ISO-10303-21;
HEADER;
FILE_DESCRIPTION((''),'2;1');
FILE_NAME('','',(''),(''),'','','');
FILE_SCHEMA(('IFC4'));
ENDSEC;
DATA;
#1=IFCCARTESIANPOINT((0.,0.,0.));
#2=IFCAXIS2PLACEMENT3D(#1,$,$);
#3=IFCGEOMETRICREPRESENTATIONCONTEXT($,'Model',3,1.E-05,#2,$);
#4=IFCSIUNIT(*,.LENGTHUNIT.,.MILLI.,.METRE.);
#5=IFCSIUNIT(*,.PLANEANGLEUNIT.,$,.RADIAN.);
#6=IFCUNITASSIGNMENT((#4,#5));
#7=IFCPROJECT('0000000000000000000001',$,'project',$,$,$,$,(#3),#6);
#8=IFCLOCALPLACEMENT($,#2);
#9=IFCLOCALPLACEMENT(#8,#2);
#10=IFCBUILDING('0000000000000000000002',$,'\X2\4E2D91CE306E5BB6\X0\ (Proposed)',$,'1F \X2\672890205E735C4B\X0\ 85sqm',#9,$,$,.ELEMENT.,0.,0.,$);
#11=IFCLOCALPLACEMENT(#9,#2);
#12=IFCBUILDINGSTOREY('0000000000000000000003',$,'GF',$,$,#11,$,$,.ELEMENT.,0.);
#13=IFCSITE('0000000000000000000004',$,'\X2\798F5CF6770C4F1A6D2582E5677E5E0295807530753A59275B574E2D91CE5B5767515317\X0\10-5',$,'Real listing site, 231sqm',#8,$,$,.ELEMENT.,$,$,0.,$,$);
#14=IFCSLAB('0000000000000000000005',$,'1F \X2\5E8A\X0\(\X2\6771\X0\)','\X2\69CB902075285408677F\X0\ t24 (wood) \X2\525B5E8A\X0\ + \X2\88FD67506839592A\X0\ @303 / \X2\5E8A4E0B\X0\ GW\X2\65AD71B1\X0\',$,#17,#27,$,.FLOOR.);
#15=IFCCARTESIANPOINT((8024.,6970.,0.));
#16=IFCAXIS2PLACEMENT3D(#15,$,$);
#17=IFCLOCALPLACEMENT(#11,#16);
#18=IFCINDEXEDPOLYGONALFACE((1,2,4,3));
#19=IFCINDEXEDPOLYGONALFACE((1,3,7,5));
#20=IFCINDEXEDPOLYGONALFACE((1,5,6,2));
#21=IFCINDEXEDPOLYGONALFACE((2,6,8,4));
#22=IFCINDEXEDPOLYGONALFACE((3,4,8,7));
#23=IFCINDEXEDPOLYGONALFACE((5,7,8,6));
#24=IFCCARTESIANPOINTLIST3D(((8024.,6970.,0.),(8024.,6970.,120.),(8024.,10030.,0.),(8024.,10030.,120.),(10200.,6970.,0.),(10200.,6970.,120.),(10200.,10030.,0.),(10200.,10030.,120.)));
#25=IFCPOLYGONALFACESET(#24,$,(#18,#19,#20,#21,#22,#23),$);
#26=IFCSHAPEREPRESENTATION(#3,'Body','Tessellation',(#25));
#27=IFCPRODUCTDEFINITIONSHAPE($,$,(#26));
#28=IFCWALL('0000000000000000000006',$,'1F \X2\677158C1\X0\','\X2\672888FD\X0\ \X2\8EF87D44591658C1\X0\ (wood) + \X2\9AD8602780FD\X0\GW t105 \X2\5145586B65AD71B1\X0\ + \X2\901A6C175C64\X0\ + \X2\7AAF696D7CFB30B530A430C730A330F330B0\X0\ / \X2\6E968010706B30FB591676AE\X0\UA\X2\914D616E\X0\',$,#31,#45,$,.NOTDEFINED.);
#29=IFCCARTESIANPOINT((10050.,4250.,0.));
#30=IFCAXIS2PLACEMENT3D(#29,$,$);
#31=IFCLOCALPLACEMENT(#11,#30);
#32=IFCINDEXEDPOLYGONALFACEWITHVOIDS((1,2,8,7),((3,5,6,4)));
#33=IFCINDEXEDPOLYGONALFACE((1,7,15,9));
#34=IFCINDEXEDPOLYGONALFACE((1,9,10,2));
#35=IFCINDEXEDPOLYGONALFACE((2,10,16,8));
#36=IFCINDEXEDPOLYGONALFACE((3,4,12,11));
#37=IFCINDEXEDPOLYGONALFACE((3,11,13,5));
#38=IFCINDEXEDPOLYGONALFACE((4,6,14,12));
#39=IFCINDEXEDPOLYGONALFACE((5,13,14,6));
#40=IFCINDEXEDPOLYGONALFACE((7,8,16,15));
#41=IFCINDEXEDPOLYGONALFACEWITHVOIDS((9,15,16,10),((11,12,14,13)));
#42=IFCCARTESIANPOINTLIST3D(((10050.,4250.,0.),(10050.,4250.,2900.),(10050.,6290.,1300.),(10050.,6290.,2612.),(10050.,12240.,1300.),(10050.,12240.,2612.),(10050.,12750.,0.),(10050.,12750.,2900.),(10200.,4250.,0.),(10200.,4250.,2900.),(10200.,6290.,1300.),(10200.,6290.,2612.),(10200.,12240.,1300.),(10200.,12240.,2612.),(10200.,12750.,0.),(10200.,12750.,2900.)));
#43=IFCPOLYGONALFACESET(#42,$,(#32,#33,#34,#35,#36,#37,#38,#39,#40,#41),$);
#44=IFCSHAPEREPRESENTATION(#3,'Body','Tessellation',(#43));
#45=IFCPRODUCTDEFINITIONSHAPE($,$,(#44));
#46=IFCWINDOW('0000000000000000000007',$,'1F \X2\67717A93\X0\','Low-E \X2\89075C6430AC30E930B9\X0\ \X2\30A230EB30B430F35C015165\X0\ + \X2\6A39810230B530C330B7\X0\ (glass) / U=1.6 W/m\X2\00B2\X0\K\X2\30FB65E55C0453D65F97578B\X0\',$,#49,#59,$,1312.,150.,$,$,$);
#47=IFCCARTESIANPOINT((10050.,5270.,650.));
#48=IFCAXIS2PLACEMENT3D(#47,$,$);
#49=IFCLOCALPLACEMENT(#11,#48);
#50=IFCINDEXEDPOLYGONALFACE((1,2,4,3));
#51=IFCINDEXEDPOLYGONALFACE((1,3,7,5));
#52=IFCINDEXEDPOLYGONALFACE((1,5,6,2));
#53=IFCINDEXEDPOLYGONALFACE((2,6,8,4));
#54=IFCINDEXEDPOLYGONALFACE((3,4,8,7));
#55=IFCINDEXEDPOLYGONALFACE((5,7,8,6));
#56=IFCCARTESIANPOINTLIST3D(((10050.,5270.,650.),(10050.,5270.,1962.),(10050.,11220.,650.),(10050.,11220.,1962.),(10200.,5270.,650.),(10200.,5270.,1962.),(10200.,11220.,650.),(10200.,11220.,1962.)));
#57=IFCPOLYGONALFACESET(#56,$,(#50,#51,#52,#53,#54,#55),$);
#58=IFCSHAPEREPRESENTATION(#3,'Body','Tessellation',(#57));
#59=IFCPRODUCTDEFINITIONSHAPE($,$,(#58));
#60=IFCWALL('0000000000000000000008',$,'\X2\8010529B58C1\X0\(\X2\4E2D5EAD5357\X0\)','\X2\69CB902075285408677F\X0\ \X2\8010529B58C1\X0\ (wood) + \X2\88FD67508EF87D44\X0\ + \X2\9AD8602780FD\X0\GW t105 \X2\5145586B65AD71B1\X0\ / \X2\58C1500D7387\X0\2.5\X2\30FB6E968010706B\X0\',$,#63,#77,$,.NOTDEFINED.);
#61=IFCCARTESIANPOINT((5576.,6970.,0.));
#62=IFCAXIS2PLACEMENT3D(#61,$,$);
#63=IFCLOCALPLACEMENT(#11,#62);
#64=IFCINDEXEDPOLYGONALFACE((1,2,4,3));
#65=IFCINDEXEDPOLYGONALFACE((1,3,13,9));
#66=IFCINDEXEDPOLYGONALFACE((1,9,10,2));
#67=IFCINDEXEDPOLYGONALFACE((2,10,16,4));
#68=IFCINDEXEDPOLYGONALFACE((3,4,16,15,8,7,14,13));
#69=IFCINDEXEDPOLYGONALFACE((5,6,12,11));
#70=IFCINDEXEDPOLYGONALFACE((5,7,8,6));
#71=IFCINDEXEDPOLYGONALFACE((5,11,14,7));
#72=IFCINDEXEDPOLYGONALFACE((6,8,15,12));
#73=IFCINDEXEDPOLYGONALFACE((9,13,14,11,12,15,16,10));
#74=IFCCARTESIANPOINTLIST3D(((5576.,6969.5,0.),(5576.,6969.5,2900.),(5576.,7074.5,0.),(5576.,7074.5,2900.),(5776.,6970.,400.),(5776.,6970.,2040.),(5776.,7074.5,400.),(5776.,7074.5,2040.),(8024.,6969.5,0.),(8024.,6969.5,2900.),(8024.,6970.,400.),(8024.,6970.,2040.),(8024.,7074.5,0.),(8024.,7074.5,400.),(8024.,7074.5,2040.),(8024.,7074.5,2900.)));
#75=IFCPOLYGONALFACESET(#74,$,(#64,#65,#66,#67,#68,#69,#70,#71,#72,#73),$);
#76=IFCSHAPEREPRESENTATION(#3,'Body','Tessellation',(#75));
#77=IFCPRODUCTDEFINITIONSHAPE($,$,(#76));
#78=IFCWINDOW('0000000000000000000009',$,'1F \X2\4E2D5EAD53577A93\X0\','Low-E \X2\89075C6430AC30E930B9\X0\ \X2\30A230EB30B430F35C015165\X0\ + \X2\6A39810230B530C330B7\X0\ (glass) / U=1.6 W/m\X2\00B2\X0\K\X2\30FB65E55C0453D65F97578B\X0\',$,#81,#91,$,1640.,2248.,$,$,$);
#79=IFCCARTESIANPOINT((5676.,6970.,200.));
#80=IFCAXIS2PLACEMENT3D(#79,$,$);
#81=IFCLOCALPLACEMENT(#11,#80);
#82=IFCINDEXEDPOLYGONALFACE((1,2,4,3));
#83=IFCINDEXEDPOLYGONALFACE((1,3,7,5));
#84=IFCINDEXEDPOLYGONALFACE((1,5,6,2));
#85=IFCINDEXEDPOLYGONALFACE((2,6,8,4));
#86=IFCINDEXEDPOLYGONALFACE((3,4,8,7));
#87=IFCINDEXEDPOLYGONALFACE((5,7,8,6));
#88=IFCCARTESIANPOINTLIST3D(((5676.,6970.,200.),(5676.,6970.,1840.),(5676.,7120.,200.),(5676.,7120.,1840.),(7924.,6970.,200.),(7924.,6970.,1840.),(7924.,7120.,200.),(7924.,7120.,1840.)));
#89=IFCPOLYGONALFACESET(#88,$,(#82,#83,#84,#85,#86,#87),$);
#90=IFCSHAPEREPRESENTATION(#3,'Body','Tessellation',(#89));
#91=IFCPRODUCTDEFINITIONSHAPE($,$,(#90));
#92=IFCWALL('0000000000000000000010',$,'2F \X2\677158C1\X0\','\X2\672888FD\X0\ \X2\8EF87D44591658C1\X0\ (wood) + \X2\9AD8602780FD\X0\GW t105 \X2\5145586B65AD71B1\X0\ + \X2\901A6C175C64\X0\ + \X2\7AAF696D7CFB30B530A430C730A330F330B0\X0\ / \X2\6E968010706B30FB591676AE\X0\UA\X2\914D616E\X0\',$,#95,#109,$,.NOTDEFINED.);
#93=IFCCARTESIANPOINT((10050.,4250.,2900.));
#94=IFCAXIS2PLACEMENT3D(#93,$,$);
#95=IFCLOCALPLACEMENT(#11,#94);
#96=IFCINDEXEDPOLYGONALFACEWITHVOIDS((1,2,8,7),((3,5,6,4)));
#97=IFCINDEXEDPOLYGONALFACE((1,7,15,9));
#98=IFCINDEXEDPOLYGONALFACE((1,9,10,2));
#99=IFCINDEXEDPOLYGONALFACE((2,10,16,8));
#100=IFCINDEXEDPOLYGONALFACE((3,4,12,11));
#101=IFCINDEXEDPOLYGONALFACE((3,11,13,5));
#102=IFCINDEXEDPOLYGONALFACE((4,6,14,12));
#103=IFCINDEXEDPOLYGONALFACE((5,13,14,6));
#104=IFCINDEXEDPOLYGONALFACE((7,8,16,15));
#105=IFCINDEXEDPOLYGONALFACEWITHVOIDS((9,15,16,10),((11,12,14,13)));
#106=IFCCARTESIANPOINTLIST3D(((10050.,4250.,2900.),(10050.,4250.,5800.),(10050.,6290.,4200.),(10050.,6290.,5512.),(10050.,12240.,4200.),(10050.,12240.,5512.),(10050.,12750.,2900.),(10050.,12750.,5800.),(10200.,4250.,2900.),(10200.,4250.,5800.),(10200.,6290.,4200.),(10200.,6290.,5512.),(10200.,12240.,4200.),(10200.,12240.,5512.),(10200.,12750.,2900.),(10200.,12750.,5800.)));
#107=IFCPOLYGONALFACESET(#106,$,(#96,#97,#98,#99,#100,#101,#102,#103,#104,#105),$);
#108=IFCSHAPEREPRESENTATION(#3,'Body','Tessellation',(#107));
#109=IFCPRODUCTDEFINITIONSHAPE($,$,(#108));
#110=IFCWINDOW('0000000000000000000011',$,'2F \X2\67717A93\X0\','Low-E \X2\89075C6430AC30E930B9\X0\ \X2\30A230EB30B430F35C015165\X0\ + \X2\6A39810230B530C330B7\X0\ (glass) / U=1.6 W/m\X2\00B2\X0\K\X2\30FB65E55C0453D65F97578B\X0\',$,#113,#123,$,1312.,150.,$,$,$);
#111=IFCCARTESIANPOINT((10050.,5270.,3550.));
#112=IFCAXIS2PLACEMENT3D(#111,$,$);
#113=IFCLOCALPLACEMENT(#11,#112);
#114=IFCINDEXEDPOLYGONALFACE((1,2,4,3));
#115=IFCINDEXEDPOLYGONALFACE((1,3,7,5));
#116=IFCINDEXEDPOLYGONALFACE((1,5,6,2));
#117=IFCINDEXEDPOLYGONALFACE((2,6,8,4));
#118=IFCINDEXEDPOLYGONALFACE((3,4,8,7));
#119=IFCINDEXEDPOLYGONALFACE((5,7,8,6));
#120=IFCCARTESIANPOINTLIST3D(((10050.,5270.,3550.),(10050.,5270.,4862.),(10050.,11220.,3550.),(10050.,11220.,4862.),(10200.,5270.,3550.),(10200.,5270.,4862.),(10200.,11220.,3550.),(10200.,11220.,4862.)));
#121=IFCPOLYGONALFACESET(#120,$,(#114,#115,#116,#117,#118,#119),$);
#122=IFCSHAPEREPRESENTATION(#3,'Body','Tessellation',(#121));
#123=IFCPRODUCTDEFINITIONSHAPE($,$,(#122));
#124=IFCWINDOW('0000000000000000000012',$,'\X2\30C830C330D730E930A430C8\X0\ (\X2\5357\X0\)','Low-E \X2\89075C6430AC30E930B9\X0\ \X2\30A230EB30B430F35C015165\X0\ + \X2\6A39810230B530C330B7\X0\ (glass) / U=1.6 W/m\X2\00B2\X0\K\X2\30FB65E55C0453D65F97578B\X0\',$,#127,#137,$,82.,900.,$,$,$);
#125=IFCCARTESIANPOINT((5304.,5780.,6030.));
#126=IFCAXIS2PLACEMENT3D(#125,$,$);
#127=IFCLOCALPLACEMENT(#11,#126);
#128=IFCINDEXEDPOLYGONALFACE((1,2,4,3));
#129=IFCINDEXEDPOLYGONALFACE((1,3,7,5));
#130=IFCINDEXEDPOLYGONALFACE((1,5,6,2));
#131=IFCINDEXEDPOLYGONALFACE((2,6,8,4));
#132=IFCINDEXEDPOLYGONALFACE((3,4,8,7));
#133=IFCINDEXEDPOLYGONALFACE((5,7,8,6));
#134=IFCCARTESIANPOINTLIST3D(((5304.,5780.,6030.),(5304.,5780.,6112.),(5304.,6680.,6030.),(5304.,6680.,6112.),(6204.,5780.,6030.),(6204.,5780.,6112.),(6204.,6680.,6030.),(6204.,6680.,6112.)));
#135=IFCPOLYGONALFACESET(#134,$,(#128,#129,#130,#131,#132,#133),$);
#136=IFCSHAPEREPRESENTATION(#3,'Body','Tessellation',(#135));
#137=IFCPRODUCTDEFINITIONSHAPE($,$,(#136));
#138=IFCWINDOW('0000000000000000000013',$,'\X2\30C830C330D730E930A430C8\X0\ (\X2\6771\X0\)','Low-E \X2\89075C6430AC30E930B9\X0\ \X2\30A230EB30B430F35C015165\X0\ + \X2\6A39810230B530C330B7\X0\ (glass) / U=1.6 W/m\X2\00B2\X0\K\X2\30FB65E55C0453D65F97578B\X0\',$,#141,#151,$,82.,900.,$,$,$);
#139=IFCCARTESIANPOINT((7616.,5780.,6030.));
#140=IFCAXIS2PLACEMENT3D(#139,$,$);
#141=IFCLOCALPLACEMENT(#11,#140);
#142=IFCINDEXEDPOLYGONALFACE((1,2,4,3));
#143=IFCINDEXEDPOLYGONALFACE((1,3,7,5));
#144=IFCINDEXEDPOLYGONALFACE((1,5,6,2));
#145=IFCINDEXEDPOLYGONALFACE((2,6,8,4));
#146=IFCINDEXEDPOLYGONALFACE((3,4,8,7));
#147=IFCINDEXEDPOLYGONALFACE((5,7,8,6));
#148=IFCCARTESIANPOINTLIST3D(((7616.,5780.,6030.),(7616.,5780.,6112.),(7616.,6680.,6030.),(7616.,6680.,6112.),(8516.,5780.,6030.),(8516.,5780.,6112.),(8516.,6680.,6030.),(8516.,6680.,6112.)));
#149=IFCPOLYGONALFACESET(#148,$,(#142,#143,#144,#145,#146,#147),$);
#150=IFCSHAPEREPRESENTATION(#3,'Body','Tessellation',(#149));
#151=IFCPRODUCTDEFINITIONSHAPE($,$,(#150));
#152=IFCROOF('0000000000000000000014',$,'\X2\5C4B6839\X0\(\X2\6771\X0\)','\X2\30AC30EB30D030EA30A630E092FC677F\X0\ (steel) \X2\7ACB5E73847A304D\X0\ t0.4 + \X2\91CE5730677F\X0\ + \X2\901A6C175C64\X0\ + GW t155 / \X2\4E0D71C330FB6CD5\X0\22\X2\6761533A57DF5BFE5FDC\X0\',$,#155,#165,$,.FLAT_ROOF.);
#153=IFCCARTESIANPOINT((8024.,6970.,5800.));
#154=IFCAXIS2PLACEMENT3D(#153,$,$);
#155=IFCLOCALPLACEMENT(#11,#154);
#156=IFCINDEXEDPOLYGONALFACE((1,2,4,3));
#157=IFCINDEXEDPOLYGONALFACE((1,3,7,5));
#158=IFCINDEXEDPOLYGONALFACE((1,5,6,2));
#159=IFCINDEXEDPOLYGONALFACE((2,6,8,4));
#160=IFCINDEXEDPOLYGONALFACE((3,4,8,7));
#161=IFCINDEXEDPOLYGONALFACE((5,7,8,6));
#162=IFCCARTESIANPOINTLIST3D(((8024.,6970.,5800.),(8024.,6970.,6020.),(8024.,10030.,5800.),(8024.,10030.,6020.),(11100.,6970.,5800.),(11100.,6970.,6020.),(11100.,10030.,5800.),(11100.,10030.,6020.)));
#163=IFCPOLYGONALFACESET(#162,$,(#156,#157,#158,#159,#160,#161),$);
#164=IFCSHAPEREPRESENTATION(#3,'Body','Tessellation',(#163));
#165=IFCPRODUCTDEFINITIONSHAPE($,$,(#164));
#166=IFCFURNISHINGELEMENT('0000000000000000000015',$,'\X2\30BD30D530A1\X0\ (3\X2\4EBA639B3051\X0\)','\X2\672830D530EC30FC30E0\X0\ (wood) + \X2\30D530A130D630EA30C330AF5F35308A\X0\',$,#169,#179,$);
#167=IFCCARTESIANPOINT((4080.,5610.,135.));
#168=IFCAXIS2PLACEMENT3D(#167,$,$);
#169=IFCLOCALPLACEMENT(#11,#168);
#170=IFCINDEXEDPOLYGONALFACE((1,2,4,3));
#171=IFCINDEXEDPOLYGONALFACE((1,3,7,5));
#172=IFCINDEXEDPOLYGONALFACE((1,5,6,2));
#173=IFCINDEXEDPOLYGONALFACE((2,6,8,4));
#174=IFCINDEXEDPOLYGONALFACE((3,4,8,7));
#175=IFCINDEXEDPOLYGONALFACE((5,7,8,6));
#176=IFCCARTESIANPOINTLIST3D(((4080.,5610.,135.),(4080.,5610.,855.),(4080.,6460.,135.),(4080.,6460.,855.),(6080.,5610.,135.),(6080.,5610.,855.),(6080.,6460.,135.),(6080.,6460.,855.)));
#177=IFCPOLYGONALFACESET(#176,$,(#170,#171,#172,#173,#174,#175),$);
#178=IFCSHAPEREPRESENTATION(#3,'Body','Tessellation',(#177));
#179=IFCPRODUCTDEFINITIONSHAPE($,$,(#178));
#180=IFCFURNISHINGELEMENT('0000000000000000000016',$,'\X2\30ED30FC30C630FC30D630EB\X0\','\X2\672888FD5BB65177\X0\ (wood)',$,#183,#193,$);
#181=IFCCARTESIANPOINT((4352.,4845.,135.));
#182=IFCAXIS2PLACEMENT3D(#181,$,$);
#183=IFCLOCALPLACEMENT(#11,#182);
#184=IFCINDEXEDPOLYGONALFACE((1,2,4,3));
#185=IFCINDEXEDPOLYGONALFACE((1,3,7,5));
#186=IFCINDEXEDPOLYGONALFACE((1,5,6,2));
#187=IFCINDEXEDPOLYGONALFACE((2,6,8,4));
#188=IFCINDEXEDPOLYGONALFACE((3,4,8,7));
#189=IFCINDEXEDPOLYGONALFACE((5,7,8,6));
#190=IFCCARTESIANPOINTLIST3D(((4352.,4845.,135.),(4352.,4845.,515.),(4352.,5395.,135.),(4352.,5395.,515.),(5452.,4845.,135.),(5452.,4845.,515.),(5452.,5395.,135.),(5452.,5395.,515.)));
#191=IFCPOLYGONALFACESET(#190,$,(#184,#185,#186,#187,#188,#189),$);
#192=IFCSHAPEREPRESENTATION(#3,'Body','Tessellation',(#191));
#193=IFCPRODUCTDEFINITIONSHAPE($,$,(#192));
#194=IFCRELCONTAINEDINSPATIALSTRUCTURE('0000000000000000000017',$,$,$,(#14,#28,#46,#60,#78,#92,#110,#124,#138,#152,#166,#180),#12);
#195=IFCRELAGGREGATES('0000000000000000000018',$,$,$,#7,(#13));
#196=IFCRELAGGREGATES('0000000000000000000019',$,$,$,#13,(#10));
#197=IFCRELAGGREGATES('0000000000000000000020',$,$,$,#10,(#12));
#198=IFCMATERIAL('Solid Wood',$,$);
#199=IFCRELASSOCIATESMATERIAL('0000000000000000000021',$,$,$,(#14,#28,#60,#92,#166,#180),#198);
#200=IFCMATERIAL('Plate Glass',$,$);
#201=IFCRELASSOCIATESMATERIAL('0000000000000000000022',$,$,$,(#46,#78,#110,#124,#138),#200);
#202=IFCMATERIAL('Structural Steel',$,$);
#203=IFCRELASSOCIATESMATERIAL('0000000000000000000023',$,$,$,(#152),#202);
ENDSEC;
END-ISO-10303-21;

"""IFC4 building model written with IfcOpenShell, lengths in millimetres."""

from ifc_helpers import new_model, si_unit, frame, frame_2d, origin, place, context, project, spatial, rectangle, extrude, material, element, fill, save


model = new_model("IFC4")

# Units and contexts
model_context = context("Model", 3, precision=1e-05, world=origin())
ifc_project = project(units=[si_unit("LENGTHUNIT", "METRE", prefix="MILLI"), si_unit("PLANEANGLEUNIT", "RADIAN")], contexts=[model_context])

# Site, building, storey
site_placement = place(None, origin())
site = spatial("IfcSite", under=ifc_project, at=site_placement, Name="福島県会津若松市門田町大字中野字村北10-5", ObjectType="Real listing site, 231sqm", CompositionType="ELEMENT", RefElevation=0.0)
building_placement = place(site_placement, origin())
building = spatial("IfcBuilding", under=site, at=building_placement, Name="中野の家 (Proposed)", ObjectType="1F 木造平屋 85sqm", CompositionType="ELEMENT", ElevationOfRefHeight=0.0, ElevationOfTerrain=0.0)
storey_placement = place(building_placement, origin())
storey = spatial("IfcBuildingStorey", under=building, at=storey_placement, Name="GF", CompositionType="ELEMENT", Elevation=0.0)

# Slab
ifc_material_1 = material(Name="Solid Wood")
slab_placement = place(storey_placement, frame((8024.0, 6970.0, 0.0)))
element("IfcSlab", 1, at=slab_placement, inside=storey, material=ifc_material_1, Name="1F 床(東)", Description="構造用合板 t24 (wood) 剛床 + 製材根太 @303 / 床下 GW断熱", PredefinedType="FLOOR", context=model_context, shape_type="SweptSolid", body=[
    extrude(rectangle(XDim=2176.0, YDim=3060.0, at=frame_2d((1088.0, 1530.0))), frame((8024.0, 6970.0, 0.0)), (0.0, 0.0, 1.0), 120.0),
])

# Walls, openings, windows
wall_1_placement = place(storey_placement, frame((10050.0, 4250.0, 0.0)))
wall_1 = element("IfcWall", 2, at=wall_1_placement, inside=storey, material=ifc_material_1, Name="1F 東壁", Description="木製 軸組外壁 (wood) + 高性能GW t105 充填断熱 + 通気層 + 窯業系サイディング / 準耐火・外皮UA配慮", PredefinedType="NOTDEFINED", context=model_context, shape_type="SweptSolid", body=[
    extrude(rectangle(XDim=150.0, YDim=8500.0, at=frame_2d((75.0, 4250.0))), frame((10050.0, 4250.0, 0.0)), (0.0, 0.0, 1.0), 2900.0),
])
opening_1_placement = place(storey_placement, frame((10050.0, 5270.0, 650.0)))
opening_1 = element("IfcOpeningElement", 3, at=opening_1_placement, cuts=wall_1, PredefinedType="NOTDEFINED", context=model_context, shape_type="SweptSolid", body=[
    extrude(rectangle(XDim=150.0, YDim=5950.0, at=frame_2d((75.0, 2975.0))), frame((10050.0, 5270.0, 650.0)), (0.0, 0.0, 1.0), 1312.0),
])
ifc_material_2 = material(Name="Plate Glass")
window_1_placement = place(storey_placement, frame((10050.0, 5270.0, 650.0)))
window_1 = element("IfcWindow", 4, at=window_1_placement, inside=storey, material=ifc_material_2, Name="1F 東窓", Description="Low-E 複層ガラス アルゴン封入 + 樹脂サッシ (glass) / U=1.6 W/m²K・日射取得型", OverallHeight=1312.0, OverallWidth=150.0, context=model_context, shape_type="SweptSolid", body=[
    extrude(rectangle(XDim=150.0, YDim=5950.0, at=frame_2d((75.0, 2975.0))), frame((10050.0, 5270.0, 650.0)), (0.0, 0.0, 1.0), 1312.0),
])
fill(opening_1, window_1)
wall_2_placement = place(storey_placement, frame((5576.0, 6970.0, 0.0)))
wall_2 = element("IfcWall", 5, at=wall_2_placement, inside=storey, material=ifc_material_1, Name="耐力壁(中庭南)", Description="構造用合板 耐力壁 (wood) + 製材軸組 + 高性能GW t105 充填断熱 / 壁倍率2.5・準耐火", PredefinedType="NOTDEFINED", context=model_context, shape_type="SweptSolid", body=[
    extrude(rectangle(XDim=2448.0, YDim=105.0, at=frame_2d((1224.0, 52.0))), frame((5576.0, 6970.0, 0.0)), (0.0, 0.0, 1.0), 2900.0),
])
opening_2_placement = place(storey_placement, frame((5676.0, 6970.0, 200.0)))
opening_2 = element("IfcOpeningElement", 6, at=opening_2_placement, cuts=wall_2, PredefinedType="NOTDEFINED", context=model_context, shape_type="SweptSolid", body=[
    extrude(rectangle(XDim=2248.0, YDim=150.0, at=frame_2d((1124.0, 75.0))), frame((5676.0, 6970.0, 200.0)), (0.0, 0.0, 1.0), 1640.0),
])
window_2_placement = place(storey_placement, frame((5676.0, 6970.0, 200.0)))
window_2 = element("IfcWindow", 7, at=window_2_placement, inside=storey, material=ifc_material_2, Name="1F 中庭南窓", Description="Low-E 複層ガラス アルゴン封入 + 樹脂サッシ (glass) / U=1.6 W/m²K・日射取得型", OverallHeight=1640.0, OverallWidth=2248.0, context=model_context, shape_type="SweptSolid", body=[
    extrude(rectangle(XDim=2248.0, YDim=150.0, at=frame_2d((1124.0, 75.0))), frame((5676.0, 6970.0, 200.0)), (0.0, 0.0, 1.0), 1640.0),
])
fill(opening_2, window_2)

# Wall, opening, window
wall_3_placement = place(storey_placement, frame((10050.0, 4250.0, 2900.0)))
wall_3 = element("IfcWall", 8, at=wall_3_placement, inside=storey, material=ifc_material_1, Name="2F 東壁", Description="木製 軸組外壁 (wood) + 高性能GW t105 充填断熱 + 通気層 + 窯業系サイディング / 準耐火・外皮UA配慮", PredefinedType="NOTDEFINED", context=model_context, shape_type="SweptSolid", body=[
    extrude(rectangle(XDim=150.0, YDim=8500.0, at=frame_2d((75.0, 4250.0))), frame((10050.0, 4250.0, 2900.0)), (0.0, 0.0, 1.0), 2900.0),
])
opening_3_placement = place(storey_placement, frame((10050.0, 5270.0, 3550.0)))
opening_3 = element("IfcOpeningElement", 9, at=opening_3_placement, cuts=wall_3, PredefinedType="NOTDEFINED", context=model_context, shape_type="SweptSolid", body=[
    extrude(rectangle(XDim=150.0, YDim=5950.0, at=frame_2d((75.0, 2975.0))), frame((10050.0, 5270.0, 3550.0)), (0.0, 0.0, 1.0), 1312.0),
])
window_3_placement = place(storey_placement, frame((10050.0, 5270.0, 3550.0)))
window_3 = element("IfcWindow", 10, at=window_3_placement, inside=storey, material=ifc_material_2, Name="2F 東窓", Description="Low-E 複層ガラス アルゴン封入 + 樹脂サッシ (glass) / U=1.6 W/m²K・日射取得型", OverallHeight=1312.0, OverallWidth=150.0, context=model_context, shape_type="SweptSolid", body=[
    extrude(rectangle(XDim=150.0, YDim=5950.0, at=frame_2d((75.0, 2975.0))), frame((10050.0, 5270.0, 3550.0)), (0.0, 0.0, 1.0), 1312.0),
])
fill(opening_3, window_3)

# Windows
window_4_placement = place(storey_placement, frame((5304.0, 5780.0, 6030.0)))
element("IfcWindow", 11, at=window_4_placement, inside=storey, material=ifc_material_2, Name="トップライト (南)", Description="Low-E 複層ガラス アルゴン封入 + 樹脂サッシ (glass) / U=1.6 W/m²K・日射取得型", OverallHeight=82.0, OverallWidth=900.0, context=model_context, shape_type="SweptSolid", body=[
    extrude(rectangle(XDim=900.0, YDim=900.0, at=frame_2d((450.0, 450.0))), frame((5304.0, 5780.0, 6030.0)), (0.0, 0.0, 1.0), 82.0),
])
window_5_placement = place(storey_placement, frame((7616.0, 5780.0, 6030.0)))
element("IfcWindow", 12, at=window_5_placement, inside=storey, material=ifc_material_2, Name="トップライト (東)", Description="Low-E 複層ガラス アルゴン封入 + 樹脂サッシ (glass) / U=1.6 W/m²K・日射取得型", OverallHeight=82.0, OverallWidth=900.0, context=model_context, shape_type="SweptSolid", body=[
    extrude(rectangle(XDim=900.0, YDim=900.0, at=frame_2d((450.0, 450.0))), frame((7616.0, 5780.0, 6030.0)), (0.0, 0.0, 1.0), 82.0),
])

# Roof
ifc_material_3 = material(Name="Structural Steel")
roof_placement = place(storey_placement, frame((8024.0, 6970.0, 5800.0)))
element("IfcRoof", 13, at=roof_placement, inside=storey, material=ifc_material_3, Name="屋根(東)", Description="ガルバリウム鋼板 (steel) 立平葺き t0.4 + 野地板 + 通気層 + GW t155 / 不燃・法22条区域対応", PredefinedType="FLAT_ROOF", context=model_context, shape_type="SweptSolid", body=[
    extrude(rectangle(XDim=3076.0, YDim=3060.0, at=frame_2d((1538.0, 1530.0))), frame((8024.0, 6970.0, 5800.0)), (0.0, 0.0, 1.0), 220.0),
])

# Furnishing elements
furnishing_1_placement = place(storey_placement, frame((4080.0, 5610.0, 135.0)))
element("IfcFurnishingElement", 14, at=furnishing_1_placement, inside=storey, material=ifc_material_1, Name="ソファ (3人掛け)", Description="木フレーム (wood) + ファブリック張り", context=model_context, shape_type="SweptSolid", body=[
    extrude(rectangle(XDim=2000.0, YDim=850.0, at=frame_2d((1000.0, 425.0))), frame((4080.0, 5610.0, 135.0)), (0.0, 0.0, 1.0), 720.0),
])
furnishing_2_placement = place(storey_placement, frame((4352.0, 4845.0, 135.0)))
element("IfcFurnishingElement", 15, at=furnishing_2_placement, inside=storey, material=ifc_material_1, Name="ローテーブル", Description="木製家具 (wood)", context=model_context, shape_type="SweptSolid", body=[
    extrude(rectangle(XDim=1100.0, YDim=550.0, at=frame_2d((550.0, 275.0))), frame((4352.0, 4845.0, 135.0)), (0.0, 0.0, 1.0), 380.0),
])

save(model, "model.ifc")
